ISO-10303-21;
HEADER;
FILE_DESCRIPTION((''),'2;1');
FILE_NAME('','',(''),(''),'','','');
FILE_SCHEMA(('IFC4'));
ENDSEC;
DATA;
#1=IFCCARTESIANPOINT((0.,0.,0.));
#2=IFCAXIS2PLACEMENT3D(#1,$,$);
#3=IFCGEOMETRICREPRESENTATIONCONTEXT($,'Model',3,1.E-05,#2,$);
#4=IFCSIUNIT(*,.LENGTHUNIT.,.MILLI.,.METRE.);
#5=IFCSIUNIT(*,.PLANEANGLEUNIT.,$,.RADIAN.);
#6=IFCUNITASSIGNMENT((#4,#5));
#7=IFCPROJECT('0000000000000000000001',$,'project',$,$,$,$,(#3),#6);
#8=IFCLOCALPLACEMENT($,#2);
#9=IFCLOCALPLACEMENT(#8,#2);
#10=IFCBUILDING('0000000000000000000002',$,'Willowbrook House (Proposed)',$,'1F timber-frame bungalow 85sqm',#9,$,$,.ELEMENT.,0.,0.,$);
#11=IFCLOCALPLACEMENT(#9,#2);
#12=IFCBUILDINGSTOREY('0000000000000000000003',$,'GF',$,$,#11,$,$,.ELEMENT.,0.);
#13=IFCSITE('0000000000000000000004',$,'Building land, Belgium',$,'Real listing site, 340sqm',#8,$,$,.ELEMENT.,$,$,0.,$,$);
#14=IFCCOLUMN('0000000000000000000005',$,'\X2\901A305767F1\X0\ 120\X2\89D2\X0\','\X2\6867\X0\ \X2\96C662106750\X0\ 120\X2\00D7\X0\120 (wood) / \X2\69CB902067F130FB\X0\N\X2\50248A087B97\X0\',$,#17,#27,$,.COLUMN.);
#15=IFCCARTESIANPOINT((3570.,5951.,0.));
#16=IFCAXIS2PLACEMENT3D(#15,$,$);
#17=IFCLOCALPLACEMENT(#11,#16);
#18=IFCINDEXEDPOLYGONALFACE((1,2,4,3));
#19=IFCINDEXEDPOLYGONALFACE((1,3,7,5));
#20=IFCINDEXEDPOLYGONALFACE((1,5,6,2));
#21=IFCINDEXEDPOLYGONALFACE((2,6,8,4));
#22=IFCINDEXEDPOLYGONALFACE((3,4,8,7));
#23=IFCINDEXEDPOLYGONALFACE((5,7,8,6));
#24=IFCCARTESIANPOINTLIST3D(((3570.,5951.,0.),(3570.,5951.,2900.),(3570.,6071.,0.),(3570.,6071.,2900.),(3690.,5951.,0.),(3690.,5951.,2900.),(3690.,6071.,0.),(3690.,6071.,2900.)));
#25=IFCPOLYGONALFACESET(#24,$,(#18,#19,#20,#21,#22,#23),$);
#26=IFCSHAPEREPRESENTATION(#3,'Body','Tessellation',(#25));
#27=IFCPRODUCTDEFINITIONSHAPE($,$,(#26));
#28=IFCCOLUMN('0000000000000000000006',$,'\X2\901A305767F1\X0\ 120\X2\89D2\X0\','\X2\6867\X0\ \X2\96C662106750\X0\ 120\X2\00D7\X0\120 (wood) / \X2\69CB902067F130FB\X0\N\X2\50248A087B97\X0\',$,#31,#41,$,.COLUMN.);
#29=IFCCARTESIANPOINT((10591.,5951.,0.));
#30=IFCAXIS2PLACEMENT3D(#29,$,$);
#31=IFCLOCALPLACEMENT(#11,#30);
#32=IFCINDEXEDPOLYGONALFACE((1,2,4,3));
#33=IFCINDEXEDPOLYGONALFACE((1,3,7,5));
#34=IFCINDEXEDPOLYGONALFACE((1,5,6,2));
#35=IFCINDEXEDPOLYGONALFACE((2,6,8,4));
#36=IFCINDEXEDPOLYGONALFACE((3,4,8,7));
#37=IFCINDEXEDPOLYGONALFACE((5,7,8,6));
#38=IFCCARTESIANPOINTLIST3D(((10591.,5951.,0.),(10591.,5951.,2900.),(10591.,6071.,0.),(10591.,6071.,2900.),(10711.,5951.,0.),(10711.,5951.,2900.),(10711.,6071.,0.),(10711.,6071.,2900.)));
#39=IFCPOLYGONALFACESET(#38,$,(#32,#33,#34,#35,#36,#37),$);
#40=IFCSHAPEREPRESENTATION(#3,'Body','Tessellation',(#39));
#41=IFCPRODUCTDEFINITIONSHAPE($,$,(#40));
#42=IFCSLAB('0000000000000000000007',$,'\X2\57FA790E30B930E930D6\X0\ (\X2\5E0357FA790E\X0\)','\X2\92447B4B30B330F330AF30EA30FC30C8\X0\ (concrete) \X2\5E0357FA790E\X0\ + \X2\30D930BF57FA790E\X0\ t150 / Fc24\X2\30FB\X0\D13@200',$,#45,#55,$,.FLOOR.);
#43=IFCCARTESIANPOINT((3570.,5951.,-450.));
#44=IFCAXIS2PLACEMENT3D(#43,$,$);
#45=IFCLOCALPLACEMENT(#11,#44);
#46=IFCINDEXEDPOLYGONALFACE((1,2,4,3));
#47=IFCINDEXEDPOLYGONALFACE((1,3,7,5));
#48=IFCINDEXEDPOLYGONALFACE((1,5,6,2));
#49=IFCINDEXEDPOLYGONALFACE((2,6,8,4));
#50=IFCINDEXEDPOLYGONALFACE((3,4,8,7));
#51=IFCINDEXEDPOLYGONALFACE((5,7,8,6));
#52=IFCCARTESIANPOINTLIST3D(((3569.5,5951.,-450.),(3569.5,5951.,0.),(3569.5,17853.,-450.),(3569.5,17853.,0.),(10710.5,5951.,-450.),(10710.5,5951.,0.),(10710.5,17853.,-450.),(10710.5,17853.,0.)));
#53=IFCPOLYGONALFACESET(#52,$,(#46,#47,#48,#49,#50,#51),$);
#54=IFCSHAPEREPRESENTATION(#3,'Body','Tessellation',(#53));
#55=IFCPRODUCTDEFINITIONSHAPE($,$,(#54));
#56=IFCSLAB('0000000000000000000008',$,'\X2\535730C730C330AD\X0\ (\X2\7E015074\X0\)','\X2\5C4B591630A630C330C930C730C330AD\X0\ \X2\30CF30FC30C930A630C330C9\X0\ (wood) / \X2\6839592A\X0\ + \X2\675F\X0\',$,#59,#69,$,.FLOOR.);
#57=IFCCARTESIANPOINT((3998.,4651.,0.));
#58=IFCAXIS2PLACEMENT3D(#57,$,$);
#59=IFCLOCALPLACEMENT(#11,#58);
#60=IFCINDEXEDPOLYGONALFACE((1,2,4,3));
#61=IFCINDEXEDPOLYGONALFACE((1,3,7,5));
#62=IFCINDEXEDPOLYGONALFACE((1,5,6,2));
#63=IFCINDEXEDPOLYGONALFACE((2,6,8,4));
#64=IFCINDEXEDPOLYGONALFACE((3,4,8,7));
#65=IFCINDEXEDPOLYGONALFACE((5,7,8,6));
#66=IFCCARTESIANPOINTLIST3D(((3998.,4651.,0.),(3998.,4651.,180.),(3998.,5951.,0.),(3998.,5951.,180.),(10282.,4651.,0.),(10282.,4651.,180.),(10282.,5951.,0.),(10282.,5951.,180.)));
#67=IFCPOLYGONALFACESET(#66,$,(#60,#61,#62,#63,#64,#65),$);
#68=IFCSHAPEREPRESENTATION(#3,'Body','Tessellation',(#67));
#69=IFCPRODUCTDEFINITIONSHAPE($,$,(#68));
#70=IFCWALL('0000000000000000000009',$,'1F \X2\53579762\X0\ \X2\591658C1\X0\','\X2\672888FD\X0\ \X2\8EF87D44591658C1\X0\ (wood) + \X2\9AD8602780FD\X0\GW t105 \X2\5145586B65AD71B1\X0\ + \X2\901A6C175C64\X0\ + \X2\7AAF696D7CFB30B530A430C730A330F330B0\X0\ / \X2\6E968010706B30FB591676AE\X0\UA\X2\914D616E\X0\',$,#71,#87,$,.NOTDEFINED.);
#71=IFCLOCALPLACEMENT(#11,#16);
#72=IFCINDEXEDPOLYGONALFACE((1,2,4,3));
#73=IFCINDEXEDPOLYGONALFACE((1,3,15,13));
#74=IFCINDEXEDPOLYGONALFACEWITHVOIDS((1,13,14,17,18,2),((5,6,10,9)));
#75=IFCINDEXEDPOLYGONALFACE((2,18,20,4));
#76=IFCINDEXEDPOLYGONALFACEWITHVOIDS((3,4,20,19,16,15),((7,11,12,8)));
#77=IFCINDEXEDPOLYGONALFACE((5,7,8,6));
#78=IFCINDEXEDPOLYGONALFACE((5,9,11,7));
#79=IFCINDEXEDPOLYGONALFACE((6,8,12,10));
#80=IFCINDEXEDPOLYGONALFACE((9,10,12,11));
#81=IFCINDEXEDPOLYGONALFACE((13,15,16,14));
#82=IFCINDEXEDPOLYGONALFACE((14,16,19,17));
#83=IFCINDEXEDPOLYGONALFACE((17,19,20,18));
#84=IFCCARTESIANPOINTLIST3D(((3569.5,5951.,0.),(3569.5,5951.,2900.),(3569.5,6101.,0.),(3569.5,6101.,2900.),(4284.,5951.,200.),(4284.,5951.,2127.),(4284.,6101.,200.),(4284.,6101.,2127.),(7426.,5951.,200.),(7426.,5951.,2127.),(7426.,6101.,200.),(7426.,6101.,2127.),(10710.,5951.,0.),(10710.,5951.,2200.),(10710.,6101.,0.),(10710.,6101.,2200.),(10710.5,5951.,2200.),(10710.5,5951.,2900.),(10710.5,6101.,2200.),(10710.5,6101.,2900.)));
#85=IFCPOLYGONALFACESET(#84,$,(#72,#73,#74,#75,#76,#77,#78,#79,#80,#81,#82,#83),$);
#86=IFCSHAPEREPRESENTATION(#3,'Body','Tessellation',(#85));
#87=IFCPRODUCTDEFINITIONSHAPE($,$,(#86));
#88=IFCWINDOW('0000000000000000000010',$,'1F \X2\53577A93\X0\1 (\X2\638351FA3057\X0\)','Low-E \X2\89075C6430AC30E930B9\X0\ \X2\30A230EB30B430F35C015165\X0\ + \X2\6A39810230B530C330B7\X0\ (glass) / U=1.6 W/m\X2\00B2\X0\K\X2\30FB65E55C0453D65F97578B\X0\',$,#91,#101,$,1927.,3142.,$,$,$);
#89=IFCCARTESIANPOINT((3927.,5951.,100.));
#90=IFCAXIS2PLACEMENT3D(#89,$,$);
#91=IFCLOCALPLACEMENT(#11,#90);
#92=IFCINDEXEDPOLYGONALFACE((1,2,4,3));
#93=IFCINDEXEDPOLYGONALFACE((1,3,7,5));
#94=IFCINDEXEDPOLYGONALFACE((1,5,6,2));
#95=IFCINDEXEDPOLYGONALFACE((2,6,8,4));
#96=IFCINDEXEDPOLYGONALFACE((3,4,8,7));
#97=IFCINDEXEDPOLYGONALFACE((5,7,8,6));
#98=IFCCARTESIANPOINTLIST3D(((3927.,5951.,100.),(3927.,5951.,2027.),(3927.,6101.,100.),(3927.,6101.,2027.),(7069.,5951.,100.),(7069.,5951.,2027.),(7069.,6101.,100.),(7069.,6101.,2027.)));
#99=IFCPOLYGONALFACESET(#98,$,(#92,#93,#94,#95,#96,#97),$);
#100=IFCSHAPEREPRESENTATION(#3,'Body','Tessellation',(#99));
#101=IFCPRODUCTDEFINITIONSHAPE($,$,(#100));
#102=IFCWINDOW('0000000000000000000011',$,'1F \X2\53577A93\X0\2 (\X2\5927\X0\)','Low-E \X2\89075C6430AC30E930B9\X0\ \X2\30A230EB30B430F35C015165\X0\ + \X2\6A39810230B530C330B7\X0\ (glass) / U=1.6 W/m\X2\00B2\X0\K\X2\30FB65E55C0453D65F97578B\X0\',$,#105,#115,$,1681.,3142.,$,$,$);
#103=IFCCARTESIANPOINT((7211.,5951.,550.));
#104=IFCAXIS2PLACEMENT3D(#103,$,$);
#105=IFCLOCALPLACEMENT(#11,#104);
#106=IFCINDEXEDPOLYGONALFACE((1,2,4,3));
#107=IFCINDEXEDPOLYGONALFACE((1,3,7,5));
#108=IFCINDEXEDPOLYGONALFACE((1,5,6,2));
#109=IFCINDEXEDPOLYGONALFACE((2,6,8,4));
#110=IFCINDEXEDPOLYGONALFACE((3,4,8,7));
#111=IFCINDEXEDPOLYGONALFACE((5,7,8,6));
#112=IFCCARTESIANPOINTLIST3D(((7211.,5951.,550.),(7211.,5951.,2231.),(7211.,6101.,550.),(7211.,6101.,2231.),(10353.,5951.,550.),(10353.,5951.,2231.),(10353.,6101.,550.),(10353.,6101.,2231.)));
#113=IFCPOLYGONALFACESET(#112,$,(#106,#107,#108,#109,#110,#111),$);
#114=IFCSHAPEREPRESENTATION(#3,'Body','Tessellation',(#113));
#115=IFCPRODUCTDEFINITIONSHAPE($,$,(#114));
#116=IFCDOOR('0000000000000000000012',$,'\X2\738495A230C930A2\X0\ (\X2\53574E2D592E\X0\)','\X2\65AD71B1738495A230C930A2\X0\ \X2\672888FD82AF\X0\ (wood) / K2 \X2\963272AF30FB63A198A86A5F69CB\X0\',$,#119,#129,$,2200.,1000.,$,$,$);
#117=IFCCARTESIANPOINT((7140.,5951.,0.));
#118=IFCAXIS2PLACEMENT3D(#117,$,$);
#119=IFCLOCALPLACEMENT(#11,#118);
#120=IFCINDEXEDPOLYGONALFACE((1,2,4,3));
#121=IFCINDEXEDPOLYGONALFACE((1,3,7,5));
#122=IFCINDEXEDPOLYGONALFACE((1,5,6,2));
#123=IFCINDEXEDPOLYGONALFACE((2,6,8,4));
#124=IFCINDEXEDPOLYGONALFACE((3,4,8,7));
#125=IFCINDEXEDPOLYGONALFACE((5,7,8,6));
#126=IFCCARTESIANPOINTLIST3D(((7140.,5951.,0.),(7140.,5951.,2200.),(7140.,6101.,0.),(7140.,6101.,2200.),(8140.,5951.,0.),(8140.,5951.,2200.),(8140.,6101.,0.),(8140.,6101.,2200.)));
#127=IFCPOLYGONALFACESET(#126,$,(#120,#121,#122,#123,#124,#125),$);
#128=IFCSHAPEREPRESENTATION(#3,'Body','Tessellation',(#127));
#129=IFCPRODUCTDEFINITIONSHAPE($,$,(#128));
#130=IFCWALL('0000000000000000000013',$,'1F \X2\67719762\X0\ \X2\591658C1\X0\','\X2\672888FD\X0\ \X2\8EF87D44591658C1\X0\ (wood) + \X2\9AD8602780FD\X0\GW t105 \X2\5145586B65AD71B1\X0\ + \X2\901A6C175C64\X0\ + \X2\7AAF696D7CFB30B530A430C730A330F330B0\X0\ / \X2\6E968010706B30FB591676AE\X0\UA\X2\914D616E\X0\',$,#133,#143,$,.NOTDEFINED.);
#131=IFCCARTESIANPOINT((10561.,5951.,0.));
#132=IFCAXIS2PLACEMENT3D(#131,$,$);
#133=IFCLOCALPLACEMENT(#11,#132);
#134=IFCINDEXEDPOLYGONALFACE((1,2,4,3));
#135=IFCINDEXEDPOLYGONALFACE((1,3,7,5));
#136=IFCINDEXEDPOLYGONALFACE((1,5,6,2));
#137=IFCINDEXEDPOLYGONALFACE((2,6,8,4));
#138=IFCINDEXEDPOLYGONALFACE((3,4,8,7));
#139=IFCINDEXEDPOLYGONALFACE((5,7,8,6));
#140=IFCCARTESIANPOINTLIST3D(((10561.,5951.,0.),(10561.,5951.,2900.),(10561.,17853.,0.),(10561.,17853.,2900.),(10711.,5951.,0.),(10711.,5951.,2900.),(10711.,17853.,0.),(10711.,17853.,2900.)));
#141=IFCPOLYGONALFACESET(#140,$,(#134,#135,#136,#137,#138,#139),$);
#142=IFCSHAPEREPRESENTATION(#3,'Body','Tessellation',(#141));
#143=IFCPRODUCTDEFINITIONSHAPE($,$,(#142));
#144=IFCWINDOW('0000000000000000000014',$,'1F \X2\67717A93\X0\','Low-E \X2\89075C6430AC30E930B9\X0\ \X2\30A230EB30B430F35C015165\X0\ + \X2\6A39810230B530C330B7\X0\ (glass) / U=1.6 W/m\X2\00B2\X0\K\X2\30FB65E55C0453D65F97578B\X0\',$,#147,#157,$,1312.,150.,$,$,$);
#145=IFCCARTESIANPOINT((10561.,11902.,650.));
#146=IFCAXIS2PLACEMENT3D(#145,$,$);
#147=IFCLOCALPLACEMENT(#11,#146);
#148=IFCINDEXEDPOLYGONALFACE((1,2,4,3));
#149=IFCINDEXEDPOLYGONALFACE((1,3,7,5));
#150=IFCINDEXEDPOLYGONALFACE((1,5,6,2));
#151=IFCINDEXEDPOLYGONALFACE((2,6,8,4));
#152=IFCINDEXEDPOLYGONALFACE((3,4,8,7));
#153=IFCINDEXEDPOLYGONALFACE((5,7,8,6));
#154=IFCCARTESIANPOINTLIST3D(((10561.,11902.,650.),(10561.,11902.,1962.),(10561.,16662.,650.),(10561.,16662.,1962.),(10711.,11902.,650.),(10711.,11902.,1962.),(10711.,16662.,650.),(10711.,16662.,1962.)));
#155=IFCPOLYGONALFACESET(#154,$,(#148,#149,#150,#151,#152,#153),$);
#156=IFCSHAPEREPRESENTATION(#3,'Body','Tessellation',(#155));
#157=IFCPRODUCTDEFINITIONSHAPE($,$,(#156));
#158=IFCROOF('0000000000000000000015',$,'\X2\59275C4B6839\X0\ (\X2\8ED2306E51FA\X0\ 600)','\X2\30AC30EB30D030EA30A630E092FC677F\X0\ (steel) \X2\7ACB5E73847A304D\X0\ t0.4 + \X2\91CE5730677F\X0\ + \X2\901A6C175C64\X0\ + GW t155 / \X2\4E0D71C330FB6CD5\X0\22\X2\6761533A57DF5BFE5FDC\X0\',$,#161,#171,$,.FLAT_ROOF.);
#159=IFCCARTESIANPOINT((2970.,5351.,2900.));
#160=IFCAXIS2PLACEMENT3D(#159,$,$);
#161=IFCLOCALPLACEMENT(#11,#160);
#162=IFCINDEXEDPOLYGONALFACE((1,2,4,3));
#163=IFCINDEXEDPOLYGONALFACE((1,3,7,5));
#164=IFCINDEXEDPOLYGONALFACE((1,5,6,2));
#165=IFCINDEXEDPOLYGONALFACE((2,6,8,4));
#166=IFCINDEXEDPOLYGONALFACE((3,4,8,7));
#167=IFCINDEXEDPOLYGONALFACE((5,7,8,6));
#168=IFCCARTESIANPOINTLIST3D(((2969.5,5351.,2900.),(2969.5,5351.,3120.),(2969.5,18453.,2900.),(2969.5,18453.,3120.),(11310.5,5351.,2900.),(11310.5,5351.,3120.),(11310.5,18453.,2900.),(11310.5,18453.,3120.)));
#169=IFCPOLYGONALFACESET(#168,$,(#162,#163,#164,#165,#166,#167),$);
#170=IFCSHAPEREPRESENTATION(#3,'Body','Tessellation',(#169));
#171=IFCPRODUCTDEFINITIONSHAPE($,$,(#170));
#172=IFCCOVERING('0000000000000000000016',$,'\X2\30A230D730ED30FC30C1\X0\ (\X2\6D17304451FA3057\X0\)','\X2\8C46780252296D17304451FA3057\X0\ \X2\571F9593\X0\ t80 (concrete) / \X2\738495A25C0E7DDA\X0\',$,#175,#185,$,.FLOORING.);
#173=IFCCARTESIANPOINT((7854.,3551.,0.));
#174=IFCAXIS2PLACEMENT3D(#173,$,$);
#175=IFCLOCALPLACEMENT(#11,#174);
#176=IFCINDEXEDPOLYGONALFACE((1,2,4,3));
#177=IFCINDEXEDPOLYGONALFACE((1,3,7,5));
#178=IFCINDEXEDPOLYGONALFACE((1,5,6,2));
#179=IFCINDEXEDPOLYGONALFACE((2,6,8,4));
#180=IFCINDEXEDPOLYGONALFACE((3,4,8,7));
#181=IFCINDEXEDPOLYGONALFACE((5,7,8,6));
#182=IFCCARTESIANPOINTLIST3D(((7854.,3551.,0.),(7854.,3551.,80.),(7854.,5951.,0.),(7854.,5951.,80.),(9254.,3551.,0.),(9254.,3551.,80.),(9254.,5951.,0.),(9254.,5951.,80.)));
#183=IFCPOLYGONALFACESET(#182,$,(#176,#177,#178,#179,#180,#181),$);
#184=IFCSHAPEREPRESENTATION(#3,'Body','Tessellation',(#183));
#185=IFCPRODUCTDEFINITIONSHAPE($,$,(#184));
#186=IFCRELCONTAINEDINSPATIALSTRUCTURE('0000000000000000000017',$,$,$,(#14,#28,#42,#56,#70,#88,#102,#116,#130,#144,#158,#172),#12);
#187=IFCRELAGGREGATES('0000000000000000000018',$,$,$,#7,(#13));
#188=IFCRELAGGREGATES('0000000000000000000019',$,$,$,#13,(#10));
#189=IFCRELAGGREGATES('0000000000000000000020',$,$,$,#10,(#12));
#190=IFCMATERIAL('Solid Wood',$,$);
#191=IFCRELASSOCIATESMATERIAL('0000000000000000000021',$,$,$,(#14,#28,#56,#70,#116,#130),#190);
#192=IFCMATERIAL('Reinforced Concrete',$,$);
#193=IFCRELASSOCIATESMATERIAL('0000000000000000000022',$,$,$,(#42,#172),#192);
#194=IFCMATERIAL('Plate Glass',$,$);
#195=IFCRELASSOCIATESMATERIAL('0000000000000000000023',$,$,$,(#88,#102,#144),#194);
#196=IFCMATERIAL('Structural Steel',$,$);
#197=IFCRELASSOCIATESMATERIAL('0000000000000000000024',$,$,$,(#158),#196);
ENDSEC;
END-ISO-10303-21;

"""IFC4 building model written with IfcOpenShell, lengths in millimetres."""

from ifc_helpers import new_model, si_unit, frame, frame_2d, origin, place, context, project, spatial, rectangle, extrude, material, element, fill, save


model = new_model("IFC4")

# Units and contexts
model_context = context("Model", 3, precision=1e-05, world=origin())
ifc_project = project(units=[si_unit("LENGTHUNIT", "METRE", prefix="MILLI"), si_unit("PLANEANGLEUNIT", "RADIAN")], contexts=[model_context])

# Site, building, storey
site_placement = place(None, origin())
site = spatial("IfcSite", under=ifc_project, at=site_placement, Name="Building land, Belgium", ObjectType="Real listing site, 340sqm", CompositionType="ELEMENT", RefElevation=0.0)
building_placement = place(site_placement, origin())
building = spatial("IfcBuilding", under=site, at=building_placement, Name="Willowbrook House (Proposed)", ObjectType="1F timber-frame bungalow 85sqm", CompositionType="ELEMENT", ElevationOfRefHeight=0.0, ElevationOfTerrain=0.0)
storey_placement = place(building_placement, origin())
storey = spatial("IfcBuildingStorey", under=building, at=storey_placement, Name="GF", CompositionType="ELEMENT", Elevation=0.0)

# Columns
ifc_material_1 = material(Name="Solid Wood")
column_1_placement = place(storey_placement, frame((3570.0, 5951.0, 0.0)))
element("IfcColumn", 1, at=column_1_placement, inside=storey, material=ifc_material_1, Name="通し柱 120角", Description="桧 集成材 120×120 (wood) / 構造柱・N値計算", PredefinedType="COLUMN", context=model_context, shape_type="SweptSolid", body=[
    extrude(rectangle(XDim=120.0, YDim=120.0, at=frame_2d((60.0, 60.0))), frame((3570.0, 5951.0, 0.0)), (0.0, 0.0, 1.0), 2900.0),
])
column_2_placement = place(storey_placement, frame((10591.0, 5951.0, 0.0)))
element("IfcColumn", 2, at=column_2_placement, inside=storey, material=ifc_material_1, Name="通し柱 120角", Description="桧 集成材 120×120 (wood) / 構造柱・N値計算", PredefinedType="COLUMN", context=model_context, shape_type="SweptSolid", body=[
    extrude(rectangle(XDim=120.0, YDim=120.0, at=frame_2d((60.0, 60.0))), frame((10591.0, 5951.0, 0.0)), (0.0, 0.0, 1.0), 2900.0),
])

# Slabs
ifc_material_2 = material(Name="Reinforced Concrete")
slab_1_placement = place(storey_placement, frame((3570.0, 5951.0, -450.0)))
element("IfcSlab", 3, at=slab_1_placement, inside=storey, material=ifc_material_2, Name="基礎スラブ (布基礎)", Description="鉄筋コンクリート (concrete) 布基礎 + ベタ基礎 t150 / Fc24・D13@200", PredefinedType="FLOOR", context=model_context, shape_type="SweptSolid", body=[
    extrude(rectangle(XDim=7141.0, YDim=11902.0, at=frame_2d((3570.0, 5951.0))), frame((3570.0, 5951.0, -450.0)), (0.0, 0.0, 1.0), 450.0),
])
slab_2_placement = place(storey_placement, frame((3998.0, 4651.0, 0.0)))
element("IfcSlab", 4, at=slab_2_placement, inside=storey, material=ifc_material_1, Name="南デッキ (縁側)", Description="屋外ウッドデッキ ハードウッド (wood) / 根太 + 束", PredefinedType="FLOOR", context=model_context, shape_type="SweptSolid", body=[
    extrude(rectangle(XDim=6284.0, YDim=1300.0, at=frame_2d((3142.0, 650.0))), frame((3998.0, 4651.0, 0.0)), (0.0, 0.0, 1.0), 180.0),
])

# Wall, openings, windows, door
wall_1_placement = place(storey_placement, frame((3570.0, 5951.0, 0.0)))
wall_1 = element("IfcWall", 5, at=wall_1_placement, inside=storey, material=ifc_material_1, Name="1F 南面 外壁", Description="木製 軸組外壁 (wood) + 高性能GW t105 充填断熱 + 通気層 + 窯業系サイディング / 準耐火・外皮UA配慮", PredefinedType="NOTDEFINED", context=model_context, shape_type="SweptSolid", body=[
    extrude(rectangle(XDim=7141.0, YDim=150.0, at=frame_2d((3570.0, 75.0))), frame((3570.0, 5951.0, 0.0)), (0.0, 0.0, 1.0), 2900.0),
])
opening_1_placement = place(storey_placement, frame((3927.0, 5951.0, 100.0)))
opening_1 = element("IfcOpeningElement", 6, at=opening_1_placement, cuts=wall_1, PredefinedType="NOTDEFINED", context=model_context, shape_type="SweptSolid", body=[
    extrude(rectangle(XDim=3142.0, YDim=150.0, at=frame_2d((1571.0, 75.0))), frame((3927.0, 5951.0, 100.0)), (0.0, 0.0, 1.0), 1927.0),
])
opening_2_placement = place(storey_placement, frame((7211.0, 5951.0, 550.0)))
opening_2 = element("IfcOpeningElement", 7, at=opening_2_placement, cuts=wall_1, PredefinedType="NOTDEFINED", context=model_context, shape_type="SweptSolid", body=[
    extrude(rectangle(XDim=3142.0, YDim=150.0, at=frame_2d((1571.0, 75.0))), frame((7211.0, 5951.0, 550.0)), (0.0, 0.0, 1.0), 1681.0),
])
opening_3_placement = place(storey_placement, frame((7140.0, 5951.0, 0.0)))
opening_3 = element("IfcOpeningElement", 8, at=opening_3_placement, cuts=wall_1, PredefinedType="NOTDEFINED", context=model_context, shape_type="SweptSolid", body=[
    extrude(rectangle(XDim=1000.0, YDim=150.0, at=frame_2d((500.0, 75.0))), frame((7140.0, 5951.0, 0.0)), (0.0, 0.0, 1.0), 2200.0),
])
ifc_material_3 = material(Name="Plate Glass")
window_1_placement = place(storey_placement, frame((3927.0, 5951.0, 100.0)))
window_1 = element("IfcWindow", 9, at=window_1_placement, inside=storey, material=ifc_material_3, Name="1F 南窓1 (掃出し)", Description="Low-E 複層ガラス アルゴン封入 + 樹脂サッシ (glass) / U=1.6 W/m²K・日射取得型", OverallHeight=1927.0, OverallWidth=3142.0, context=model_context, shape_type="SweptSolid", body=[
    extrude(rectangle(XDim=3142.0, YDim=150.0, at=frame_2d((1571.0, 75.0))), frame((3927.0, 5951.0, 100.0)), (0.0, 0.0, 1.0), 1927.0),
])
fill(opening_1, window_1)
window_2_placement = place(storey_placement, frame((7211.0, 5951.0, 550.0)))
window_2 = element("IfcWindow", 10, at=window_2_placement, inside=storey, material=ifc_material_3, Name="1F 南窓2 (大)", Description="Low-E 複層ガラス アルゴン封入 + 樹脂サッシ (glass) / U=1.6 W/m²K・日射取得型", OverallHeight=1681.0, OverallWidth=3142.0, context=model_context, shape_type="SweptSolid", body=[
    extrude(rectangle(XDim=3142.0, YDim=150.0, at=frame_2d((1571.0, 75.0))), frame((7211.0, 5951.0, 550.0)), (0.0, 0.0, 1.0), 1681.0),
])
fill(opening_2, window_2)
door_placement = place(storey_placement, frame((7140.0, 5951.0, 0.0)))
door = element("IfcDoor", 11, at=door_placement, inside=storey, material=ifc_material_1, Name="玄関ドア (南中央)", Description="断熱玄関ドア 木製芯 (wood) / K2 防犯・採風機構", OverallHeight=2200.0, OverallWidth=1000.0, context=model_context, shape_type="SweptSolid", body=[
    extrude(rectangle(XDim=1000.0, YDim=150.0, at=frame_2d((500.0, 75.0))), frame((7140.0, 5951.0, 0.0)), (0.0, 0.0, 1.0), 2200.0),
])
fill(opening_3, door)

# Wall, opening, window
wall_2_placement = place(storey_placement, frame((10561.0, 5951.0, 0.0)))
wall_2 = element("IfcWall", 12, at=wall_2_placement, inside=storey, material=ifc_material_1, Name="1F 東面 外壁", Description="木製 軸組外壁 (wood) + 高性能GW t105 充填断熱 + 通気層 + 窯業系サイディング / 準耐火・外皮UA配慮", PredefinedType="NOTDEFINED", context=model_context, shape_type="SweptSolid", body=[
    extrude(rectangle(XDim=150.0, YDim=11902.0, at=frame_2d((75.0, 5951.0))), frame((10561.0, 5951.0, 0.0)), (0.0, 0.0, 1.0), 2900.0),
])
opening_4_placement = place(storey_placement, frame((10561.0, 11902.0, 650.0)))
opening_4 = element("IfcOpeningElement", 13, at=opening_4_placement, cuts=wall_2, PredefinedType="NOTDEFINED", context=model_context, shape_type="SweptSolid", body=[
    extrude(rectangle(XDim=150.0, YDim=4760.0, at=frame_2d((75.0, 2380.0))), frame((10561.0, 11902.0, 650.0)), (0.0, 0.0, 1.0), 1312.0),
])
window_3_placement = place(storey_placement, frame((10561.0, 11902.0, 650.0)))
window_3 = element("IfcWindow", 14, at=window_3_placement, inside=storey, material=ifc_material_3, Name="1F 東窓", Description="Low-E 複層ガラス アルゴン封入 + 樹脂サッシ (glass) / U=1.6 W/m²K・日射取得型", OverallHeight=1312.0, OverallWidth=150.0, context=model_context, shape_type="SweptSolid", body=[
    extrude(rectangle(XDim=150.0, YDim=4760.0, at=frame_2d((75.0, 2380.0))), frame((10561.0, 11902.0, 650.0)), (0.0, 0.0, 1.0), 1312.0),
])
fill(opening_4, window_3)

# Roof
ifc_material_4 = material(Name="Structural Steel")
roof_placement = place(storey_placement, frame((2970.0, 5351.0, 2900.0)))
element("IfcRoof", 15, at=roof_placement, inside=storey, material=ifc_material_4, Name="大屋根 (軒の出 600)", Description="ガルバリウム鋼板 (steel) 立平葺き t0.4 + 野地板 + 通気層 + GW t155 / 不燃・法22条区域対応", PredefinedType="FLAT_ROOF", context=model_context, shape_type="SweptSolid", body=[
    extrude(rectangle(XDim=8341.0, YDim=13102.0, at=frame_2d((4170.0, 6551.0))), frame((2970.0, 5351.0, 2900.0)), (0.0, 0.0, 1.0), 220.0),
])

# Covering
covering_1_placement = place(storey_placement, frame((7854.0, 3551.0, 0.0)))
element("IfcCovering", 16, at=covering_1_placement, inside=storey, material=ifc_material_2, Name="アプローチ (洗い出し)", Description="豆砂利洗い出し 土間 t80 (concrete) / 玄関導線", PredefinedType="FLOORING", context=model_context, shape_type="SweptSolid", body=[
    extrude(rectangle(XDim=1400.0, YDim=2400.0, at=frame_2d((700.0, 1200.0))), frame((7854.0, 3551.0, 0.0)), (0.0, 0.0, 1.0), 80.0),
])

save(model, "model.ifc")
